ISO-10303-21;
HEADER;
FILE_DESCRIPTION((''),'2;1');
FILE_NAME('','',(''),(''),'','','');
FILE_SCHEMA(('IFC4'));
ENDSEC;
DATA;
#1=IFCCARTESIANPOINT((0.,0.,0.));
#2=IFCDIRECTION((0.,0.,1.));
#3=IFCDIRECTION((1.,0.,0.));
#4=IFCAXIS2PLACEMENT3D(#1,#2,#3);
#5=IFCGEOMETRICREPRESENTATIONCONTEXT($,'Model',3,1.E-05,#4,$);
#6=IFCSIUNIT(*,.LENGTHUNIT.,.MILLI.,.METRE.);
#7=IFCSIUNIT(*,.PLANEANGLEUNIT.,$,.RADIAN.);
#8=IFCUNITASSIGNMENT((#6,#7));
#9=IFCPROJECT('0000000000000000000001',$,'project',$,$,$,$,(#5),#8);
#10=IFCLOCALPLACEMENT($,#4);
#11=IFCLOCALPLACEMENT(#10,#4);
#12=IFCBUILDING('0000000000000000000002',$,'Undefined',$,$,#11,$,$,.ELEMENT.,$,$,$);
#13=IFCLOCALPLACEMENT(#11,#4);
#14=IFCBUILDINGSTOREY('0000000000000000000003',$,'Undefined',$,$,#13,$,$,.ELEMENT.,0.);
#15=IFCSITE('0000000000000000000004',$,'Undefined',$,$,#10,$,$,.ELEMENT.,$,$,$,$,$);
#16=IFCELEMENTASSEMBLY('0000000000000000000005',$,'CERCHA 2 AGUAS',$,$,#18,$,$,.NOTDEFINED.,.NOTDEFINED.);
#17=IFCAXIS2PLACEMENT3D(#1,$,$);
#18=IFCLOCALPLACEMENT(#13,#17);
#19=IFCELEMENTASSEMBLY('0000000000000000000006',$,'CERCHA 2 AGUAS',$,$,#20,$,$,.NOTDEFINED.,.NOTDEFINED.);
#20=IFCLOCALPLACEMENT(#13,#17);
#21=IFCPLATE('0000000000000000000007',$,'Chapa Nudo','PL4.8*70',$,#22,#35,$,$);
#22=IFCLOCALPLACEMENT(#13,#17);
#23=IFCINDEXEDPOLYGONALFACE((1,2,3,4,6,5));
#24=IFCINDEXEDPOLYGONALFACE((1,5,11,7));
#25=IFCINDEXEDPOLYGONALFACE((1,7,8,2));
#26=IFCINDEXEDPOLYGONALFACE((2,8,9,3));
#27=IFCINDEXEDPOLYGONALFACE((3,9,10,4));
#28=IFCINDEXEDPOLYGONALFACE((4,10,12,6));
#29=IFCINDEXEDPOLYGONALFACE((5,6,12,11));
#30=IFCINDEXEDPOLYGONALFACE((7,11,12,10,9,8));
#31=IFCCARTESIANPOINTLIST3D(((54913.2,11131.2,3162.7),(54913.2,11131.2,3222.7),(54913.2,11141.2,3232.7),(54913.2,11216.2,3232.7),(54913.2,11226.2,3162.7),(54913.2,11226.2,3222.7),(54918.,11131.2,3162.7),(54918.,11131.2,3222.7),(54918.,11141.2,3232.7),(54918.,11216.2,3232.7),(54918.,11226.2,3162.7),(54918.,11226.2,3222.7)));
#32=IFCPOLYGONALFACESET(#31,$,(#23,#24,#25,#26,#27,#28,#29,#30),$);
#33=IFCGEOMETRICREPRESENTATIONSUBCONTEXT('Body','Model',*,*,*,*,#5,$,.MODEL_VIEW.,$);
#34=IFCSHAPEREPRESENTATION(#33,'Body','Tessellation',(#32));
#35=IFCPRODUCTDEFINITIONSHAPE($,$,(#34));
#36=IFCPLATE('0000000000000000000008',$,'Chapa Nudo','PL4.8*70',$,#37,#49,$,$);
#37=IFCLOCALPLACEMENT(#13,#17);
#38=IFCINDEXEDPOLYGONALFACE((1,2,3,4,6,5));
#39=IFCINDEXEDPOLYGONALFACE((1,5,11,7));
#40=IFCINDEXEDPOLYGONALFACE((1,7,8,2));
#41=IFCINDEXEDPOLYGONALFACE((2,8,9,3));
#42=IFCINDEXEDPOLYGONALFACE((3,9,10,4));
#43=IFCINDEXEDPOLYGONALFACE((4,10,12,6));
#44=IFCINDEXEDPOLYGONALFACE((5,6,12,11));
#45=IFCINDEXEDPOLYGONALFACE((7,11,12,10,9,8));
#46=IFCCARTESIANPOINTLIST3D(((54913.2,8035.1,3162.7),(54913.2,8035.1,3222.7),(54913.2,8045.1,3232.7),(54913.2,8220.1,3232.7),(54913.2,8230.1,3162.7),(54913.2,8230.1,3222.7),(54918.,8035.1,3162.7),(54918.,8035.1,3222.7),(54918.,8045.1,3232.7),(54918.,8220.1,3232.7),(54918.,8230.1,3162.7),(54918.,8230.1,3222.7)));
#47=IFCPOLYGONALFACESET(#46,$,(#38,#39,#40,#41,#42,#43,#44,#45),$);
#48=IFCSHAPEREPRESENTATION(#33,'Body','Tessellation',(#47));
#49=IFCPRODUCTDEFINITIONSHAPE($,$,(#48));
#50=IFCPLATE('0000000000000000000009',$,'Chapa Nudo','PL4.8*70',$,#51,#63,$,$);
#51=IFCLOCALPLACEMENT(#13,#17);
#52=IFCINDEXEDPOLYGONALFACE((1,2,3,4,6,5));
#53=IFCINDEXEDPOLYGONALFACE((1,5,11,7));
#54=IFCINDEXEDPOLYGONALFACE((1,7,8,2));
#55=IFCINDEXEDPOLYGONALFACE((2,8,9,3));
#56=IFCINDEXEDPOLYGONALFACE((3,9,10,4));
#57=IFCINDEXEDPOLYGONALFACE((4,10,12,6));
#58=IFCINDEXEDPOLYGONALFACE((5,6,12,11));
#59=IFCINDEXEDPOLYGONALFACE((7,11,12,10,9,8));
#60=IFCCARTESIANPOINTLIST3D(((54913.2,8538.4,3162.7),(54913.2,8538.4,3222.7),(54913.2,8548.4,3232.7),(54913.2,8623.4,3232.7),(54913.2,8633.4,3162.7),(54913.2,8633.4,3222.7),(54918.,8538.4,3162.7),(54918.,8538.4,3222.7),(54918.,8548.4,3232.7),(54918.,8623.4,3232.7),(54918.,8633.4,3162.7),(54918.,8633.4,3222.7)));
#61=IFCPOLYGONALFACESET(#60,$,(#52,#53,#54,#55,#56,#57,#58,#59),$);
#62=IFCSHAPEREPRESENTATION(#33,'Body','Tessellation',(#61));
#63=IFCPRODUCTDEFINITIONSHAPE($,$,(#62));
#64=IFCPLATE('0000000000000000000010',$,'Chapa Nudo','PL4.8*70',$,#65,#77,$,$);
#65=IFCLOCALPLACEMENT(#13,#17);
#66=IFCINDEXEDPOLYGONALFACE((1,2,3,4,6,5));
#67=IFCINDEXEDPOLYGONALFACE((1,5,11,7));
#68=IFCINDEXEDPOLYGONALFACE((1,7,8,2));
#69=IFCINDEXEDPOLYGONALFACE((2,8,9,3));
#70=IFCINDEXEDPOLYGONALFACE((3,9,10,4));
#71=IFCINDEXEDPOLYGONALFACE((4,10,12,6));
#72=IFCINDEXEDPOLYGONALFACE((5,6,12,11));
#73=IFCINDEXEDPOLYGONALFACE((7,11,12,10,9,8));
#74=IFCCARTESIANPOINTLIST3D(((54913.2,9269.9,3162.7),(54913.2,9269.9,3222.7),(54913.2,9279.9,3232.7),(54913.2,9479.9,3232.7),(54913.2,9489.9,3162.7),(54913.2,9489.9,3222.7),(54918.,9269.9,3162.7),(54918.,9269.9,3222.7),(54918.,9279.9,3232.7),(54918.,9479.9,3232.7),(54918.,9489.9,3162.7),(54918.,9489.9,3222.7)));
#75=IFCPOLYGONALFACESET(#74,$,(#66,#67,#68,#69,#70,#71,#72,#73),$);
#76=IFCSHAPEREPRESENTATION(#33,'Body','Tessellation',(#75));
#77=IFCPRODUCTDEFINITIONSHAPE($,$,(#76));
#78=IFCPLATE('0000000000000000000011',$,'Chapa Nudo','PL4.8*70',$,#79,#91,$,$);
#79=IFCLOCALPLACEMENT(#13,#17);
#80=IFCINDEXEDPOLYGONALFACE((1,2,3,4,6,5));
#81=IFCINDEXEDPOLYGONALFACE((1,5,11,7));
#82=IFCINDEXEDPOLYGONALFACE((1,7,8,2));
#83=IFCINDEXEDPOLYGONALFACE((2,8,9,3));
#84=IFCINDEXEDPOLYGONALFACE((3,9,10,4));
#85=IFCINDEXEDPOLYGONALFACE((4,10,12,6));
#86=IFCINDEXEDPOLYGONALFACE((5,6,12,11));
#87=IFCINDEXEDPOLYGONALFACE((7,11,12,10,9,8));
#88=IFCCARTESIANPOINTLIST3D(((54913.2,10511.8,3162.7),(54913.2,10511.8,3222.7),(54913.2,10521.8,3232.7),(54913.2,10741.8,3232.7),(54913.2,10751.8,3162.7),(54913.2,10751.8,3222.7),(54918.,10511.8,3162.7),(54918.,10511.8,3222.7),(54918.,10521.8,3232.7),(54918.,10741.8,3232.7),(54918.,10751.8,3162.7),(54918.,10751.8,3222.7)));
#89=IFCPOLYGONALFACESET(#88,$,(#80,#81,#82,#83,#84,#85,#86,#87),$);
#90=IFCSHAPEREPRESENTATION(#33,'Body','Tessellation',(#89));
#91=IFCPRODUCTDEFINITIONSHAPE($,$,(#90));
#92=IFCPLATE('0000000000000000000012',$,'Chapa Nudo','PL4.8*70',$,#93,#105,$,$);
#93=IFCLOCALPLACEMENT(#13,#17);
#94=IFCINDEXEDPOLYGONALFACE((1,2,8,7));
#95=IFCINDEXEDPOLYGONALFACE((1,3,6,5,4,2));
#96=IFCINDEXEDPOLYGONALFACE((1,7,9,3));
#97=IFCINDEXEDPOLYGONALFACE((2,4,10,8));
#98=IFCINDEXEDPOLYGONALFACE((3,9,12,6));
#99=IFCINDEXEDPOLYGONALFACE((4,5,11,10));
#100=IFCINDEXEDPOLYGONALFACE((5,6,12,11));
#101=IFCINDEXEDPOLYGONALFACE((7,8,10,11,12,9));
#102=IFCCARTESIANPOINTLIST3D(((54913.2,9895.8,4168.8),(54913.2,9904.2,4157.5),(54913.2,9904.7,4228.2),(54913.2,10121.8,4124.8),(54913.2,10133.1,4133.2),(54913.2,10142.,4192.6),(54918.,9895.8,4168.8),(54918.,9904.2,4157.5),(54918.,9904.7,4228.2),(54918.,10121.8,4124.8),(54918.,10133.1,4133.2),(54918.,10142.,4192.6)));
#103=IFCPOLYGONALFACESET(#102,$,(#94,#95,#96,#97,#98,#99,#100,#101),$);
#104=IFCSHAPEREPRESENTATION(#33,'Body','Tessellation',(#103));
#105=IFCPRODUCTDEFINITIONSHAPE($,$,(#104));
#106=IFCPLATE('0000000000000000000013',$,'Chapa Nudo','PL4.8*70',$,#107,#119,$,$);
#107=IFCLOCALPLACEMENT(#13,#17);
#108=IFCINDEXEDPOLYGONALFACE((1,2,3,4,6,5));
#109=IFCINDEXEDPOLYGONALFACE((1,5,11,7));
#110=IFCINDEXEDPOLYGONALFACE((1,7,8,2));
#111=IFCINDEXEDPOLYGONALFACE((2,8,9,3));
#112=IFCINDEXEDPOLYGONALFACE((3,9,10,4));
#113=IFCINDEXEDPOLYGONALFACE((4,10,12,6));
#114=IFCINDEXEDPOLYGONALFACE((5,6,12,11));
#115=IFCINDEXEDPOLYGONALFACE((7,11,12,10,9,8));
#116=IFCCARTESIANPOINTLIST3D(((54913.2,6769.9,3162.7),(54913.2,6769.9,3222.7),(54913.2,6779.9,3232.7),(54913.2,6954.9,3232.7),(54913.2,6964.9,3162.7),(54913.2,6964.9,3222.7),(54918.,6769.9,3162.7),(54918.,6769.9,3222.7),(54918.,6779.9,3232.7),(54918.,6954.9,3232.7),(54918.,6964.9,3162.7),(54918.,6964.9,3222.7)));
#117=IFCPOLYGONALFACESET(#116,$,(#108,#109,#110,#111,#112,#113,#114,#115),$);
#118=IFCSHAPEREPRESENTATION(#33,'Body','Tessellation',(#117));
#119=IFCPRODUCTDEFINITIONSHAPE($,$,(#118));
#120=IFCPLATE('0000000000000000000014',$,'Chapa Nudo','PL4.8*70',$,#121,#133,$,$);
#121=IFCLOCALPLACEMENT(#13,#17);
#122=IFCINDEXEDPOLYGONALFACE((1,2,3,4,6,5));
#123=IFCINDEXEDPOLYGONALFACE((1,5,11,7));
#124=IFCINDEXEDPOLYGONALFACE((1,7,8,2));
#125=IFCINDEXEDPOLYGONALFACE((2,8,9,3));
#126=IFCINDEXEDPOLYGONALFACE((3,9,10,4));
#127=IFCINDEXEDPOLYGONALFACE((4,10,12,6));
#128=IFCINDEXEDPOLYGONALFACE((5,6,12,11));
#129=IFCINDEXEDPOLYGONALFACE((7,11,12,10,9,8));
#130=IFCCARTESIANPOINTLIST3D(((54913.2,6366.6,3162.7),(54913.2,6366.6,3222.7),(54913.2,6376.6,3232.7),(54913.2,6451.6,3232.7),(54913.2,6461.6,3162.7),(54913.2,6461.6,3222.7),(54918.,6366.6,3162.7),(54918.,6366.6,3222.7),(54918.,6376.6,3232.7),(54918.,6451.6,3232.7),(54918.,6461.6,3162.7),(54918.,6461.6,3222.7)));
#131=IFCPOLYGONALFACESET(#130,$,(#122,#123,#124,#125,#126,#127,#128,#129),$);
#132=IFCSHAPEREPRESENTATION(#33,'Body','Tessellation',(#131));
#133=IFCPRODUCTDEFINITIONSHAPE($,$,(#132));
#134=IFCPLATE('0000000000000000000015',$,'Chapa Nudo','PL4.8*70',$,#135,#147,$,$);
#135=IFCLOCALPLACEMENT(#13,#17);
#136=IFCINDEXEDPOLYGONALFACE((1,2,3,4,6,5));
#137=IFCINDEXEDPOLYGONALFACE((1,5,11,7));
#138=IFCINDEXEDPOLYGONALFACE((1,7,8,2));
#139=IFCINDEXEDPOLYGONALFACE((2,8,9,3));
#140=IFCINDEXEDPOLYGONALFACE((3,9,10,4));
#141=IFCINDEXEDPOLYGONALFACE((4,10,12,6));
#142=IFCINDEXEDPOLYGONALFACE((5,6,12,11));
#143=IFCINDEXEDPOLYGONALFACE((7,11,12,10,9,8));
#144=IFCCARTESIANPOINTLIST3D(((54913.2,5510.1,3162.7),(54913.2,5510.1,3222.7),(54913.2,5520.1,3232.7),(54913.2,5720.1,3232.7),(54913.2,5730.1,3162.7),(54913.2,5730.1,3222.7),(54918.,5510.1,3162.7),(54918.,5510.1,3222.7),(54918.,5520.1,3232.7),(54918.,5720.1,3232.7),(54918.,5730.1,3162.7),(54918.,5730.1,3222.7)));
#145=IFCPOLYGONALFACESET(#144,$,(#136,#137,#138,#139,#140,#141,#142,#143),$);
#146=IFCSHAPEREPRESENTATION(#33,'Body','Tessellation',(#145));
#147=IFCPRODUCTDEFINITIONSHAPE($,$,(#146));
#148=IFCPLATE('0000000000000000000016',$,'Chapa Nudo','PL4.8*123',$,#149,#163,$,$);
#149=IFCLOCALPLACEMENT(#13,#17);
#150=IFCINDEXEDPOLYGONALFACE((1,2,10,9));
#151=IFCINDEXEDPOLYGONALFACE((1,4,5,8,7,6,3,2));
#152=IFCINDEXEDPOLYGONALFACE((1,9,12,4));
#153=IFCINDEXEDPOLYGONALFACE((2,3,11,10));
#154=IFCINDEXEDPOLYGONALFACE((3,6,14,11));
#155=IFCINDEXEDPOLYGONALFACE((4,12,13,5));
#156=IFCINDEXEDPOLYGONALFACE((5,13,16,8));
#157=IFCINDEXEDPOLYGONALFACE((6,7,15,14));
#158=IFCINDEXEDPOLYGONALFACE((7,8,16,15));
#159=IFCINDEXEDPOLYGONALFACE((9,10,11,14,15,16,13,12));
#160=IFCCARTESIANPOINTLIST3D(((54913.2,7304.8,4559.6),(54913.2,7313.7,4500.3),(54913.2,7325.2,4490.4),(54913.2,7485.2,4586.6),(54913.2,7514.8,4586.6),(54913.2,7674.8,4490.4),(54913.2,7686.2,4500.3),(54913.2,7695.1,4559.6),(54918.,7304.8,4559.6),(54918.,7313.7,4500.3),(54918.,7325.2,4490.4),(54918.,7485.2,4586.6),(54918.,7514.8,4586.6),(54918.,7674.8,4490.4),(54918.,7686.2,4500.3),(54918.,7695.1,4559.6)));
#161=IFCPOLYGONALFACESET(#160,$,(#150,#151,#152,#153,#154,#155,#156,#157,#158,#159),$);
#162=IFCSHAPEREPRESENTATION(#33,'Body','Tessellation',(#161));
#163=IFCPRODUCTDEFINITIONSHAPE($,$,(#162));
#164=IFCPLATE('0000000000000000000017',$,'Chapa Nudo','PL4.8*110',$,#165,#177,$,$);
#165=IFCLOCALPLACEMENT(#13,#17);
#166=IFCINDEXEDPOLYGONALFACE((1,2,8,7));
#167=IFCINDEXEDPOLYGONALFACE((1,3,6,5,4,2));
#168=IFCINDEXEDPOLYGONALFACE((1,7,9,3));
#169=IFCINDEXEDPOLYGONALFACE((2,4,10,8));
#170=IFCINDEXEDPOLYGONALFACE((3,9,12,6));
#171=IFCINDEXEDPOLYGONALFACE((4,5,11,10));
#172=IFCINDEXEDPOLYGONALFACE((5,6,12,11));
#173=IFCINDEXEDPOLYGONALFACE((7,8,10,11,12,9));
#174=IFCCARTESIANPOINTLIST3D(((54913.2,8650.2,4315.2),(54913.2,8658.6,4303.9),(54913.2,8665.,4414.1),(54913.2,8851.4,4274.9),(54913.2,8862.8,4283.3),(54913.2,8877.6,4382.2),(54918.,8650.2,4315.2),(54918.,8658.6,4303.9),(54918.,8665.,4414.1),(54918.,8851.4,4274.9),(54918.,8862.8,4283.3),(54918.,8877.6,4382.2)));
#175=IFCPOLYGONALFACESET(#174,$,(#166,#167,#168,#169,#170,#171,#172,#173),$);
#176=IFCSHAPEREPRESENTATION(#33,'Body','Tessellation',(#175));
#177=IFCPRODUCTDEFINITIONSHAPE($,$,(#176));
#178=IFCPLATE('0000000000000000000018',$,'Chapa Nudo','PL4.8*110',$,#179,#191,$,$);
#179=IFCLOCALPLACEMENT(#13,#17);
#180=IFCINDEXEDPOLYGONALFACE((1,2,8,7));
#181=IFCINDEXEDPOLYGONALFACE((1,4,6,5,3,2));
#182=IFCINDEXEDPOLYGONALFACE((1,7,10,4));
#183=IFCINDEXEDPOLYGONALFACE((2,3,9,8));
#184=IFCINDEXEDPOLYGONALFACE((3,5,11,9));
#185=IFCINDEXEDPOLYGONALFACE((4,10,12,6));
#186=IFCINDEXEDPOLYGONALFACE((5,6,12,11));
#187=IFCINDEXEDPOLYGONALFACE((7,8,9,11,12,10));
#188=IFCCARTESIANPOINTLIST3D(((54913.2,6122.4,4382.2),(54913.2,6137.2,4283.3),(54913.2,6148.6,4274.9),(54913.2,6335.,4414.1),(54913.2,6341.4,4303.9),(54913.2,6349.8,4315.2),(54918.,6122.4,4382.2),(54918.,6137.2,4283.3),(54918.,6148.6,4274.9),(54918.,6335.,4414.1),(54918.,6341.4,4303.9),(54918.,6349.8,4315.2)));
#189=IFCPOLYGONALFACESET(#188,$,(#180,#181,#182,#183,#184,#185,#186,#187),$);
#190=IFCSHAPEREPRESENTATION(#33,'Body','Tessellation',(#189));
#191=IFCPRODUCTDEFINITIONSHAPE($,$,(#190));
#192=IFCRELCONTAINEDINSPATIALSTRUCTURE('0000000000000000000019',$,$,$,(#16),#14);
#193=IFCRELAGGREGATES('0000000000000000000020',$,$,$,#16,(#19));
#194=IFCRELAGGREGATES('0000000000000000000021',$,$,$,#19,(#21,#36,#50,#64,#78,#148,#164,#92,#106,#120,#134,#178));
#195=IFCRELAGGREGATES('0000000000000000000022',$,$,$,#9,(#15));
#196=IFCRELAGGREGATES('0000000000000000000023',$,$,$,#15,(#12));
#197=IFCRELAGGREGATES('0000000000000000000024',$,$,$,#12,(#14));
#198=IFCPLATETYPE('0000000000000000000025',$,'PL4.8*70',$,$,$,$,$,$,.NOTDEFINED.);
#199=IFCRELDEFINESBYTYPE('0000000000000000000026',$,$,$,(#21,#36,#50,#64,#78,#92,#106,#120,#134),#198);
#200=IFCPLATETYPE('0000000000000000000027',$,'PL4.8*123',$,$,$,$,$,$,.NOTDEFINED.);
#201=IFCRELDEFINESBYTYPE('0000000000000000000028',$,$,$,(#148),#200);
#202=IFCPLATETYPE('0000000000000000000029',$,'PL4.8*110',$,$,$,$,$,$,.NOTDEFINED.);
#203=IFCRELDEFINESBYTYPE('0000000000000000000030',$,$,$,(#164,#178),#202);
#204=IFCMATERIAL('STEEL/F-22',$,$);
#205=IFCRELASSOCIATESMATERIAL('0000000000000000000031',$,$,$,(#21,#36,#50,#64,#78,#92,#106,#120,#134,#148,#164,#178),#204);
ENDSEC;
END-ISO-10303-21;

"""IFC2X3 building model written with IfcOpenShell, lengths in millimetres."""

from ifc_helpers import new_model, si_unit, frame, origin_with_axes, place, context, subcontext, project, spatial, polyline, outline, extrude, material, type_object, element, aggregate, save


model = new_model("IFC2X3")

# Units and contexts
model_context = context("Model", 3, precision=1e-05, world=origin_with_axes())
body_context = subcontext(model_context, "Body", "Model", "MODEL_VIEW")
ifc_project = project(units=[si_unit("LENGTHUNIT", "METRE", prefix="MILLI"), si_unit("PLANEANGLEUNIT", "RADIAN")], contexts=[model_context])

# Site, building, storey
site_placement = place(None, origin_with_axes())
site = spatial("IfcSite", under=ifc_project, at=site_placement, Name="Undefined", CompositionType="ELEMENT")
building_placement = place(site_placement, origin_with_axes())
building = spatial("IfcBuilding", under=site, at=building_placement, Name="Undefined", CompositionType="ELEMENT")
storey_placement = place(building_placement, origin_with_axes())
storey = spatial("IfcBuildingStorey", under=building, at=storey_placement, Name="Undefined", CompositionType="ELEMENT", Elevation=0.0)

# Element assemblies, plates
assembly_1_placement = place(storey_placement, origin_with_axes())
assembly_1 = element("IfcElementAssembly", 1, at=assembly_1_placement, inside=storey, Name="CERCHA 2 AGUAS", AssemblyPlace="NOTDEFINED", PredefinedType="NOTDEFINED")
assembly_2_placement = place(assembly_1_placement, origin_with_axes())
assembly_2 = element("IfcElementAssembly", 2, at=assembly_2_placement, Name="CERCHA 2 AGUAS", AssemblyPlace="NOTDEFINED", PredefinedType="NOTDEFINED")
aggregate(assembly_1, [assembly_2])
ifc_material_1 = material(Name="STEEL/F-22")
plate_type_1 = type_object("IfcPlateType", Name="PL4.8*70", PredefinedType="NOTDEFINED")
plate_1_placement = place(assembly_2_placement, frame((54915.6, 11226.2, 3232.7), z_axis=(-1.0, 0.0, 0.0), x_axis=(0.0, 0.0, -1.0)))
plate_1 = element("IfcPlate", 3, at=plate_1_placement, type_object=plate_type_1, material=ifc_material_1, Name="Chapa Nudo", Description="PL4.8*70", context=body_context, shape_type="SweptSolid", body=[
    extrude(outline(polyline([(0.0, 10.0), (10.0, 0.0), (70.0, 0.0), (70.0, 95.0), (10.0, 95.0), (0.0, 85.0), (0.0, 10.0)])), frame((0.0, 0.0, -2.4), z_axis=(0.0, 0.0, 1.0), x_axis=(1.0, 0.0, 0.0)), (0.0, 0.0, 1.0), 4.8),
])
plate_2_placement = place(assembly_2_placement, frame((54915.6, 8230.1, 3232.7), z_axis=(-1.0, 0.0, 0.0), x_axis=(0.0, 0.0, -1.0)))
plate_2 = element("IfcPlate", 4, at=plate_2_placement, type_object=plate_type_1, material=ifc_material_1, Name="Chapa Nudo", Description="PL4.8*70", context=body_context, shape_type="SweptSolid", body=[
    extrude(outline(polyline([(0.0, 10.0), (10.0, 0.0), (70.0, 0.0), (70.0, 195.0), (10.0, 195.0), (0.0, 185.0), (0.0, 10.0)])), frame((0.0, 0.0, -2.4), z_axis=(0.0, 0.0, 1.0), x_axis=(1.0, 0.0, 0.0)), (0.0, 0.0, 1.0), 4.8),
])
plate_3_placement = place(assembly_2_placement, frame((54915.6, 8633.4, 3232.7), z_axis=(-1.0, 0.0, 0.0), x_axis=(0.0, 0.0, -1.0)))
plate_3 = element("IfcPlate", 5, at=plate_3_placement, type_object=plate_type_1, material=ifc_material_1, Name="Chapa Nudo", Description="PL4.8*70", context=body_context, shape_type="SweptSolid", body=[
    extrude(outline(polyline([(0.0, 10.0), (10.0, 0.0), (70.0, 0.0), (70.0, 95.0), (10.0, 95.0), (0.0, 85.0), (0.0, 10.0)])), frame((0.0, 0.0, -2.4), z_axis=(0.0, 0.0, 1.0), x_axis=(1.0, 0.0, 0.0)), (0.0, 0.0, 1.0), 4.8),
])
plate_4_placement = place(assembly_2_placement, frame((54915.6, 9489.9, 3232.7), z_axis=(-1.0, 0.0, 0.0), x_axis=(0.0, 0.0, -1.0)))
plate_4 = element("IfcPlate", 6, at=plate_4_placement, type_object=plate_type_1, material=ifc_material_1, Name="Chapa Nudo", Description="PL4.8*70", context=body_context, shape_type="SweptSolid", body=[
    extrude(outline(polyline([(0.0, 10.0), (10.0, 0.0), (70.0, 0.0), (70.0, 220.0), (10.0, 220.0), (0.0, 210.0), (0.0, 10.0)])), frame((0.0, 0.0, -2.4), z_axis=(0.0, 0.0, 1.0), x_axis=(1.0, 0.0, 0.0)), (0.0, 0.0, 1.0), 4.8),
])
plate_5_placement = place(assembly_2_placement, frame((54915.6, 10751.8, 3232.7), z_axis=(-1.0, 0.0, 0.0), x_axis=(0.0, 0.0, -1.0)))
plate_5 = element("IfcPlate", 7, at=plate_5_placement, type_object=plate_type_1, material=ifc_material_1, Name="Chapa Nudo", Description="PL4.8*70", context=body_context, shape_type="SweptSolid", body=[
    extrude(outline(polyline([(0.0, 10.0), (10.0, 0.0), (70.0, 0.0), (70.0, 240.0), (10.0, 240.0), (0.0, 230.0), (0.0, 10.0)])), frame((0.0, 0.0, -2.4), z_axis=(0.0, 0.0, 1.0), x_axis=(1.0, 0.0, 0.0)), (0.0, 0.0, 1.0), 4.8),
])
plate_6_placement = place(assembly_2_placement, frame((54915.6, 10142.0, 4192.6), z_axis=(-1.0, 0.0, 0.0), x_axis=(0.0, -0.148335, -0.988937)))
plate_6 = element("IfcPlate", 8, at=plate_6_placement, type_object=plate_type_1, material=ifc_material_1, Name="Chapa Nudo", Description="PL4.8*70", context=body_context, shape_type="SweptSolid", body=[
    extrude(outline(polyline([(0.0, 0.0), (60.0, 0.0), (70.0, 10.0), (70.0, 230.0), (60.0, 240.0), (0.0, 240.0), (0.0, 0.0)])), frame((0.0, 0.0, -2.4), z_axis=(0.0, 0.0, 1.0), x_axis=(1.0, 0.0, 0.0)), (0.0, 0.0, 1.0), 4.8),
])
plate_7_placement = place(assembly_2_placement, frame((54915.6, 6769.9, 3232.7), z_axis=(1.0, 0.0, 0.0), x_axis=(0.0, 0.0, -1.0)))
plate_7 = element("IfcPlate", 9, at=plate_7_placement, type_object=plate_type_1, material=ifc_material_1, Name="Chapa Nudo", Description="PL4.8*70", context=body_context, shape_type="SweptSolid", body=[
    extrude(outline(polyline([(0.0, 10.0), (10.0, 0.0), (70.0, 0.0), (70.0, 195.0), (10.0, 195.0), (0.0, 185.0), (0.0, 10.0)])), frame((0.0, 0.0, -2.4), z_axis=(0.0, 0.0, 1.0), x_axis=(1.0, 0.0, 0.0)), (0.0, 0.0, 1.0), 4.8),
])
plate_8_placement = place(assembly_2_placement, frame((54915.6, 6366.6, 3232.7), z_axis=(1.0, 0.0, 0.0), x_axis=(0.0, 0.0, -1.0)))
plate_8 = element("IfcPlate", 10, at=plate_8_placement, type_object=plate_type_1, material=ifc_material_1, Name="Chapa Nudo", Description="PL4.8*70", context=body_context, shape_type="SweptSolid", body=[
    extrude(outline(polyline([(0.0, 10.0), (10.0, 0.0), (70.0, 0.0), (70.0, 95.0), (10.0, 95.0), (0.0, 85.0), (0.0, 10.0)])), frame((0.0, 0.0, -2.4), z_axis=(0.0, 0.0, 1.0), x_axis=(1.0, 0.0, 0.0)), (0.0, 0.0, 1.0), 4.8),
])
plate_9_placement = place(assembly_2_placement, frame((54915.6, 5510.1, 3232.7), z_axis=(1.0, 0.0, 0.0), x_axis=(0.0, 0.0, -1.0)))
plate_9 = element("IfcPlate", 11, at=plate_9_placement, type_object=plate_type_1, material=ifc_material_1, Name="Chapa Nudo", Description="PL4.8*70", context=body_context, shape_type="SweptSolid", body=[
    extrude(outline(polyline([(0.0, 10.0), (10.0, 0.0), (70.0, 0.0), (70.0, 220.0), (10.0, 220.0), (0.0, 210.0), (0.0, 10.0)])), frame((0.0, 0.0, -2.4), z_axis=(0.0, 0.0, 1.0), x_axis=(1.0, 0.0, 0.0)), (0.0, 0.0, 1.0), 4.8),
])
plate_type_2 = type_object("IfcPlateType", Name="PL4.8*123", PredefinedType="NOTDEFINED")
plate_10_placement = place(assembly_2_placement, frame((54915.6, 7695.1, 4559.6), z_axis=(-1.0, 0.0, 0.0), x_axis=(0.0, -0.148335, -0.988937)))
plate_10 = element("IfcPlate", 12, at=plate_10_placement, type_object=plate_type_2, material=ifc_material_1, Name="Chapa Nudo", Description="PL4.8*123", context=body_context, shape_type="SweptSolid", body=[
    extrude(outline(polyline([(0.0, 0.0), (60.0, 0.0), (71.5, 9.9), (123.3, 355.6), (115.3, 368.4), (57.9, 386.0), (4.4, 211.7), (0.0, 182.3), (0.0, 0.0)])), frame((0.0, 0.0, -2.4), z_axis=(0.0, 0.0, 1.0), x_axis=(1.0, 0.0, 0.0)), (0.0, 0.0, 1.0), 4.8),
])
plate_type_3 = type_object("IfcPlateType", Name="PL4.8*110", PredefinedType="NOTDEFINED")
plate_11_placement = place(assembly_2_placement, frame((54915.6, 8877.6, 4382.2), z_axis=(-1.0, 0.0, 0.0), x_axis=(0.0, -0.148335, -0.988937)))
plate_11 = element("IfcPlate", 13, at=plate_11_placement, type_object=plate_type_3, material=ifc_material_1, Name="Chapa Nudo", Description="PL4.8*110", context=body_context, shape_type="SweptSolid", body=[
    extrude(outline(polyline([(0.0, 0.0), (100.0, 0.0), (110.0, 10.0), (110.0, 205.0), (100.0, 215.0), (0.0, 215.0), (0.0, 0.0)])), frame((0.0, 0.0, -2.4), z_axis=(0.0, 0.0, 1.0), x_axis=(1.0, 0.0, 0.0)), (0.0, 0.0, 1.0), 4.8),
])
plate_12_placement = place(assembly_2_placement, frame((54915.6, 6122.4, 4382.2), z_axis=(1.0, 0.0, 0.0), x_axis=(0.0, 0.148335, -0.988937)))
plate_12 = element("IfcPlate", 14, at=plate_12_placement, type_object=plate_type_3, material=ifc_material_1, Name="Chapa Nudo", Description="PL4.8*110", context=body_context, shape_type="SweptSolid", body=[
    extrude(outline(polyline([(0.0, 0.0), (100.0, 0.0), (110.0, 10.0), (110.0, 205.0), (100.0, 215.0), (0.0, 215.0), (0.0, 0.0)])), frame((0.0, 0.0, -2.4), z_axis=(0.0, 0.0, 1.0), x_axis=(1.0, 0.0, 0.0)), (0.0, 0.0, 1.0), 4.8),
])

aggregate(assembly_2, [plate_1, plate_2, plate_3, plate_4, plate_5, plate_10, plate_11, plate_6, plate_7, plate_8, plate_9, plate_12])

save(model, "model.ifc")
